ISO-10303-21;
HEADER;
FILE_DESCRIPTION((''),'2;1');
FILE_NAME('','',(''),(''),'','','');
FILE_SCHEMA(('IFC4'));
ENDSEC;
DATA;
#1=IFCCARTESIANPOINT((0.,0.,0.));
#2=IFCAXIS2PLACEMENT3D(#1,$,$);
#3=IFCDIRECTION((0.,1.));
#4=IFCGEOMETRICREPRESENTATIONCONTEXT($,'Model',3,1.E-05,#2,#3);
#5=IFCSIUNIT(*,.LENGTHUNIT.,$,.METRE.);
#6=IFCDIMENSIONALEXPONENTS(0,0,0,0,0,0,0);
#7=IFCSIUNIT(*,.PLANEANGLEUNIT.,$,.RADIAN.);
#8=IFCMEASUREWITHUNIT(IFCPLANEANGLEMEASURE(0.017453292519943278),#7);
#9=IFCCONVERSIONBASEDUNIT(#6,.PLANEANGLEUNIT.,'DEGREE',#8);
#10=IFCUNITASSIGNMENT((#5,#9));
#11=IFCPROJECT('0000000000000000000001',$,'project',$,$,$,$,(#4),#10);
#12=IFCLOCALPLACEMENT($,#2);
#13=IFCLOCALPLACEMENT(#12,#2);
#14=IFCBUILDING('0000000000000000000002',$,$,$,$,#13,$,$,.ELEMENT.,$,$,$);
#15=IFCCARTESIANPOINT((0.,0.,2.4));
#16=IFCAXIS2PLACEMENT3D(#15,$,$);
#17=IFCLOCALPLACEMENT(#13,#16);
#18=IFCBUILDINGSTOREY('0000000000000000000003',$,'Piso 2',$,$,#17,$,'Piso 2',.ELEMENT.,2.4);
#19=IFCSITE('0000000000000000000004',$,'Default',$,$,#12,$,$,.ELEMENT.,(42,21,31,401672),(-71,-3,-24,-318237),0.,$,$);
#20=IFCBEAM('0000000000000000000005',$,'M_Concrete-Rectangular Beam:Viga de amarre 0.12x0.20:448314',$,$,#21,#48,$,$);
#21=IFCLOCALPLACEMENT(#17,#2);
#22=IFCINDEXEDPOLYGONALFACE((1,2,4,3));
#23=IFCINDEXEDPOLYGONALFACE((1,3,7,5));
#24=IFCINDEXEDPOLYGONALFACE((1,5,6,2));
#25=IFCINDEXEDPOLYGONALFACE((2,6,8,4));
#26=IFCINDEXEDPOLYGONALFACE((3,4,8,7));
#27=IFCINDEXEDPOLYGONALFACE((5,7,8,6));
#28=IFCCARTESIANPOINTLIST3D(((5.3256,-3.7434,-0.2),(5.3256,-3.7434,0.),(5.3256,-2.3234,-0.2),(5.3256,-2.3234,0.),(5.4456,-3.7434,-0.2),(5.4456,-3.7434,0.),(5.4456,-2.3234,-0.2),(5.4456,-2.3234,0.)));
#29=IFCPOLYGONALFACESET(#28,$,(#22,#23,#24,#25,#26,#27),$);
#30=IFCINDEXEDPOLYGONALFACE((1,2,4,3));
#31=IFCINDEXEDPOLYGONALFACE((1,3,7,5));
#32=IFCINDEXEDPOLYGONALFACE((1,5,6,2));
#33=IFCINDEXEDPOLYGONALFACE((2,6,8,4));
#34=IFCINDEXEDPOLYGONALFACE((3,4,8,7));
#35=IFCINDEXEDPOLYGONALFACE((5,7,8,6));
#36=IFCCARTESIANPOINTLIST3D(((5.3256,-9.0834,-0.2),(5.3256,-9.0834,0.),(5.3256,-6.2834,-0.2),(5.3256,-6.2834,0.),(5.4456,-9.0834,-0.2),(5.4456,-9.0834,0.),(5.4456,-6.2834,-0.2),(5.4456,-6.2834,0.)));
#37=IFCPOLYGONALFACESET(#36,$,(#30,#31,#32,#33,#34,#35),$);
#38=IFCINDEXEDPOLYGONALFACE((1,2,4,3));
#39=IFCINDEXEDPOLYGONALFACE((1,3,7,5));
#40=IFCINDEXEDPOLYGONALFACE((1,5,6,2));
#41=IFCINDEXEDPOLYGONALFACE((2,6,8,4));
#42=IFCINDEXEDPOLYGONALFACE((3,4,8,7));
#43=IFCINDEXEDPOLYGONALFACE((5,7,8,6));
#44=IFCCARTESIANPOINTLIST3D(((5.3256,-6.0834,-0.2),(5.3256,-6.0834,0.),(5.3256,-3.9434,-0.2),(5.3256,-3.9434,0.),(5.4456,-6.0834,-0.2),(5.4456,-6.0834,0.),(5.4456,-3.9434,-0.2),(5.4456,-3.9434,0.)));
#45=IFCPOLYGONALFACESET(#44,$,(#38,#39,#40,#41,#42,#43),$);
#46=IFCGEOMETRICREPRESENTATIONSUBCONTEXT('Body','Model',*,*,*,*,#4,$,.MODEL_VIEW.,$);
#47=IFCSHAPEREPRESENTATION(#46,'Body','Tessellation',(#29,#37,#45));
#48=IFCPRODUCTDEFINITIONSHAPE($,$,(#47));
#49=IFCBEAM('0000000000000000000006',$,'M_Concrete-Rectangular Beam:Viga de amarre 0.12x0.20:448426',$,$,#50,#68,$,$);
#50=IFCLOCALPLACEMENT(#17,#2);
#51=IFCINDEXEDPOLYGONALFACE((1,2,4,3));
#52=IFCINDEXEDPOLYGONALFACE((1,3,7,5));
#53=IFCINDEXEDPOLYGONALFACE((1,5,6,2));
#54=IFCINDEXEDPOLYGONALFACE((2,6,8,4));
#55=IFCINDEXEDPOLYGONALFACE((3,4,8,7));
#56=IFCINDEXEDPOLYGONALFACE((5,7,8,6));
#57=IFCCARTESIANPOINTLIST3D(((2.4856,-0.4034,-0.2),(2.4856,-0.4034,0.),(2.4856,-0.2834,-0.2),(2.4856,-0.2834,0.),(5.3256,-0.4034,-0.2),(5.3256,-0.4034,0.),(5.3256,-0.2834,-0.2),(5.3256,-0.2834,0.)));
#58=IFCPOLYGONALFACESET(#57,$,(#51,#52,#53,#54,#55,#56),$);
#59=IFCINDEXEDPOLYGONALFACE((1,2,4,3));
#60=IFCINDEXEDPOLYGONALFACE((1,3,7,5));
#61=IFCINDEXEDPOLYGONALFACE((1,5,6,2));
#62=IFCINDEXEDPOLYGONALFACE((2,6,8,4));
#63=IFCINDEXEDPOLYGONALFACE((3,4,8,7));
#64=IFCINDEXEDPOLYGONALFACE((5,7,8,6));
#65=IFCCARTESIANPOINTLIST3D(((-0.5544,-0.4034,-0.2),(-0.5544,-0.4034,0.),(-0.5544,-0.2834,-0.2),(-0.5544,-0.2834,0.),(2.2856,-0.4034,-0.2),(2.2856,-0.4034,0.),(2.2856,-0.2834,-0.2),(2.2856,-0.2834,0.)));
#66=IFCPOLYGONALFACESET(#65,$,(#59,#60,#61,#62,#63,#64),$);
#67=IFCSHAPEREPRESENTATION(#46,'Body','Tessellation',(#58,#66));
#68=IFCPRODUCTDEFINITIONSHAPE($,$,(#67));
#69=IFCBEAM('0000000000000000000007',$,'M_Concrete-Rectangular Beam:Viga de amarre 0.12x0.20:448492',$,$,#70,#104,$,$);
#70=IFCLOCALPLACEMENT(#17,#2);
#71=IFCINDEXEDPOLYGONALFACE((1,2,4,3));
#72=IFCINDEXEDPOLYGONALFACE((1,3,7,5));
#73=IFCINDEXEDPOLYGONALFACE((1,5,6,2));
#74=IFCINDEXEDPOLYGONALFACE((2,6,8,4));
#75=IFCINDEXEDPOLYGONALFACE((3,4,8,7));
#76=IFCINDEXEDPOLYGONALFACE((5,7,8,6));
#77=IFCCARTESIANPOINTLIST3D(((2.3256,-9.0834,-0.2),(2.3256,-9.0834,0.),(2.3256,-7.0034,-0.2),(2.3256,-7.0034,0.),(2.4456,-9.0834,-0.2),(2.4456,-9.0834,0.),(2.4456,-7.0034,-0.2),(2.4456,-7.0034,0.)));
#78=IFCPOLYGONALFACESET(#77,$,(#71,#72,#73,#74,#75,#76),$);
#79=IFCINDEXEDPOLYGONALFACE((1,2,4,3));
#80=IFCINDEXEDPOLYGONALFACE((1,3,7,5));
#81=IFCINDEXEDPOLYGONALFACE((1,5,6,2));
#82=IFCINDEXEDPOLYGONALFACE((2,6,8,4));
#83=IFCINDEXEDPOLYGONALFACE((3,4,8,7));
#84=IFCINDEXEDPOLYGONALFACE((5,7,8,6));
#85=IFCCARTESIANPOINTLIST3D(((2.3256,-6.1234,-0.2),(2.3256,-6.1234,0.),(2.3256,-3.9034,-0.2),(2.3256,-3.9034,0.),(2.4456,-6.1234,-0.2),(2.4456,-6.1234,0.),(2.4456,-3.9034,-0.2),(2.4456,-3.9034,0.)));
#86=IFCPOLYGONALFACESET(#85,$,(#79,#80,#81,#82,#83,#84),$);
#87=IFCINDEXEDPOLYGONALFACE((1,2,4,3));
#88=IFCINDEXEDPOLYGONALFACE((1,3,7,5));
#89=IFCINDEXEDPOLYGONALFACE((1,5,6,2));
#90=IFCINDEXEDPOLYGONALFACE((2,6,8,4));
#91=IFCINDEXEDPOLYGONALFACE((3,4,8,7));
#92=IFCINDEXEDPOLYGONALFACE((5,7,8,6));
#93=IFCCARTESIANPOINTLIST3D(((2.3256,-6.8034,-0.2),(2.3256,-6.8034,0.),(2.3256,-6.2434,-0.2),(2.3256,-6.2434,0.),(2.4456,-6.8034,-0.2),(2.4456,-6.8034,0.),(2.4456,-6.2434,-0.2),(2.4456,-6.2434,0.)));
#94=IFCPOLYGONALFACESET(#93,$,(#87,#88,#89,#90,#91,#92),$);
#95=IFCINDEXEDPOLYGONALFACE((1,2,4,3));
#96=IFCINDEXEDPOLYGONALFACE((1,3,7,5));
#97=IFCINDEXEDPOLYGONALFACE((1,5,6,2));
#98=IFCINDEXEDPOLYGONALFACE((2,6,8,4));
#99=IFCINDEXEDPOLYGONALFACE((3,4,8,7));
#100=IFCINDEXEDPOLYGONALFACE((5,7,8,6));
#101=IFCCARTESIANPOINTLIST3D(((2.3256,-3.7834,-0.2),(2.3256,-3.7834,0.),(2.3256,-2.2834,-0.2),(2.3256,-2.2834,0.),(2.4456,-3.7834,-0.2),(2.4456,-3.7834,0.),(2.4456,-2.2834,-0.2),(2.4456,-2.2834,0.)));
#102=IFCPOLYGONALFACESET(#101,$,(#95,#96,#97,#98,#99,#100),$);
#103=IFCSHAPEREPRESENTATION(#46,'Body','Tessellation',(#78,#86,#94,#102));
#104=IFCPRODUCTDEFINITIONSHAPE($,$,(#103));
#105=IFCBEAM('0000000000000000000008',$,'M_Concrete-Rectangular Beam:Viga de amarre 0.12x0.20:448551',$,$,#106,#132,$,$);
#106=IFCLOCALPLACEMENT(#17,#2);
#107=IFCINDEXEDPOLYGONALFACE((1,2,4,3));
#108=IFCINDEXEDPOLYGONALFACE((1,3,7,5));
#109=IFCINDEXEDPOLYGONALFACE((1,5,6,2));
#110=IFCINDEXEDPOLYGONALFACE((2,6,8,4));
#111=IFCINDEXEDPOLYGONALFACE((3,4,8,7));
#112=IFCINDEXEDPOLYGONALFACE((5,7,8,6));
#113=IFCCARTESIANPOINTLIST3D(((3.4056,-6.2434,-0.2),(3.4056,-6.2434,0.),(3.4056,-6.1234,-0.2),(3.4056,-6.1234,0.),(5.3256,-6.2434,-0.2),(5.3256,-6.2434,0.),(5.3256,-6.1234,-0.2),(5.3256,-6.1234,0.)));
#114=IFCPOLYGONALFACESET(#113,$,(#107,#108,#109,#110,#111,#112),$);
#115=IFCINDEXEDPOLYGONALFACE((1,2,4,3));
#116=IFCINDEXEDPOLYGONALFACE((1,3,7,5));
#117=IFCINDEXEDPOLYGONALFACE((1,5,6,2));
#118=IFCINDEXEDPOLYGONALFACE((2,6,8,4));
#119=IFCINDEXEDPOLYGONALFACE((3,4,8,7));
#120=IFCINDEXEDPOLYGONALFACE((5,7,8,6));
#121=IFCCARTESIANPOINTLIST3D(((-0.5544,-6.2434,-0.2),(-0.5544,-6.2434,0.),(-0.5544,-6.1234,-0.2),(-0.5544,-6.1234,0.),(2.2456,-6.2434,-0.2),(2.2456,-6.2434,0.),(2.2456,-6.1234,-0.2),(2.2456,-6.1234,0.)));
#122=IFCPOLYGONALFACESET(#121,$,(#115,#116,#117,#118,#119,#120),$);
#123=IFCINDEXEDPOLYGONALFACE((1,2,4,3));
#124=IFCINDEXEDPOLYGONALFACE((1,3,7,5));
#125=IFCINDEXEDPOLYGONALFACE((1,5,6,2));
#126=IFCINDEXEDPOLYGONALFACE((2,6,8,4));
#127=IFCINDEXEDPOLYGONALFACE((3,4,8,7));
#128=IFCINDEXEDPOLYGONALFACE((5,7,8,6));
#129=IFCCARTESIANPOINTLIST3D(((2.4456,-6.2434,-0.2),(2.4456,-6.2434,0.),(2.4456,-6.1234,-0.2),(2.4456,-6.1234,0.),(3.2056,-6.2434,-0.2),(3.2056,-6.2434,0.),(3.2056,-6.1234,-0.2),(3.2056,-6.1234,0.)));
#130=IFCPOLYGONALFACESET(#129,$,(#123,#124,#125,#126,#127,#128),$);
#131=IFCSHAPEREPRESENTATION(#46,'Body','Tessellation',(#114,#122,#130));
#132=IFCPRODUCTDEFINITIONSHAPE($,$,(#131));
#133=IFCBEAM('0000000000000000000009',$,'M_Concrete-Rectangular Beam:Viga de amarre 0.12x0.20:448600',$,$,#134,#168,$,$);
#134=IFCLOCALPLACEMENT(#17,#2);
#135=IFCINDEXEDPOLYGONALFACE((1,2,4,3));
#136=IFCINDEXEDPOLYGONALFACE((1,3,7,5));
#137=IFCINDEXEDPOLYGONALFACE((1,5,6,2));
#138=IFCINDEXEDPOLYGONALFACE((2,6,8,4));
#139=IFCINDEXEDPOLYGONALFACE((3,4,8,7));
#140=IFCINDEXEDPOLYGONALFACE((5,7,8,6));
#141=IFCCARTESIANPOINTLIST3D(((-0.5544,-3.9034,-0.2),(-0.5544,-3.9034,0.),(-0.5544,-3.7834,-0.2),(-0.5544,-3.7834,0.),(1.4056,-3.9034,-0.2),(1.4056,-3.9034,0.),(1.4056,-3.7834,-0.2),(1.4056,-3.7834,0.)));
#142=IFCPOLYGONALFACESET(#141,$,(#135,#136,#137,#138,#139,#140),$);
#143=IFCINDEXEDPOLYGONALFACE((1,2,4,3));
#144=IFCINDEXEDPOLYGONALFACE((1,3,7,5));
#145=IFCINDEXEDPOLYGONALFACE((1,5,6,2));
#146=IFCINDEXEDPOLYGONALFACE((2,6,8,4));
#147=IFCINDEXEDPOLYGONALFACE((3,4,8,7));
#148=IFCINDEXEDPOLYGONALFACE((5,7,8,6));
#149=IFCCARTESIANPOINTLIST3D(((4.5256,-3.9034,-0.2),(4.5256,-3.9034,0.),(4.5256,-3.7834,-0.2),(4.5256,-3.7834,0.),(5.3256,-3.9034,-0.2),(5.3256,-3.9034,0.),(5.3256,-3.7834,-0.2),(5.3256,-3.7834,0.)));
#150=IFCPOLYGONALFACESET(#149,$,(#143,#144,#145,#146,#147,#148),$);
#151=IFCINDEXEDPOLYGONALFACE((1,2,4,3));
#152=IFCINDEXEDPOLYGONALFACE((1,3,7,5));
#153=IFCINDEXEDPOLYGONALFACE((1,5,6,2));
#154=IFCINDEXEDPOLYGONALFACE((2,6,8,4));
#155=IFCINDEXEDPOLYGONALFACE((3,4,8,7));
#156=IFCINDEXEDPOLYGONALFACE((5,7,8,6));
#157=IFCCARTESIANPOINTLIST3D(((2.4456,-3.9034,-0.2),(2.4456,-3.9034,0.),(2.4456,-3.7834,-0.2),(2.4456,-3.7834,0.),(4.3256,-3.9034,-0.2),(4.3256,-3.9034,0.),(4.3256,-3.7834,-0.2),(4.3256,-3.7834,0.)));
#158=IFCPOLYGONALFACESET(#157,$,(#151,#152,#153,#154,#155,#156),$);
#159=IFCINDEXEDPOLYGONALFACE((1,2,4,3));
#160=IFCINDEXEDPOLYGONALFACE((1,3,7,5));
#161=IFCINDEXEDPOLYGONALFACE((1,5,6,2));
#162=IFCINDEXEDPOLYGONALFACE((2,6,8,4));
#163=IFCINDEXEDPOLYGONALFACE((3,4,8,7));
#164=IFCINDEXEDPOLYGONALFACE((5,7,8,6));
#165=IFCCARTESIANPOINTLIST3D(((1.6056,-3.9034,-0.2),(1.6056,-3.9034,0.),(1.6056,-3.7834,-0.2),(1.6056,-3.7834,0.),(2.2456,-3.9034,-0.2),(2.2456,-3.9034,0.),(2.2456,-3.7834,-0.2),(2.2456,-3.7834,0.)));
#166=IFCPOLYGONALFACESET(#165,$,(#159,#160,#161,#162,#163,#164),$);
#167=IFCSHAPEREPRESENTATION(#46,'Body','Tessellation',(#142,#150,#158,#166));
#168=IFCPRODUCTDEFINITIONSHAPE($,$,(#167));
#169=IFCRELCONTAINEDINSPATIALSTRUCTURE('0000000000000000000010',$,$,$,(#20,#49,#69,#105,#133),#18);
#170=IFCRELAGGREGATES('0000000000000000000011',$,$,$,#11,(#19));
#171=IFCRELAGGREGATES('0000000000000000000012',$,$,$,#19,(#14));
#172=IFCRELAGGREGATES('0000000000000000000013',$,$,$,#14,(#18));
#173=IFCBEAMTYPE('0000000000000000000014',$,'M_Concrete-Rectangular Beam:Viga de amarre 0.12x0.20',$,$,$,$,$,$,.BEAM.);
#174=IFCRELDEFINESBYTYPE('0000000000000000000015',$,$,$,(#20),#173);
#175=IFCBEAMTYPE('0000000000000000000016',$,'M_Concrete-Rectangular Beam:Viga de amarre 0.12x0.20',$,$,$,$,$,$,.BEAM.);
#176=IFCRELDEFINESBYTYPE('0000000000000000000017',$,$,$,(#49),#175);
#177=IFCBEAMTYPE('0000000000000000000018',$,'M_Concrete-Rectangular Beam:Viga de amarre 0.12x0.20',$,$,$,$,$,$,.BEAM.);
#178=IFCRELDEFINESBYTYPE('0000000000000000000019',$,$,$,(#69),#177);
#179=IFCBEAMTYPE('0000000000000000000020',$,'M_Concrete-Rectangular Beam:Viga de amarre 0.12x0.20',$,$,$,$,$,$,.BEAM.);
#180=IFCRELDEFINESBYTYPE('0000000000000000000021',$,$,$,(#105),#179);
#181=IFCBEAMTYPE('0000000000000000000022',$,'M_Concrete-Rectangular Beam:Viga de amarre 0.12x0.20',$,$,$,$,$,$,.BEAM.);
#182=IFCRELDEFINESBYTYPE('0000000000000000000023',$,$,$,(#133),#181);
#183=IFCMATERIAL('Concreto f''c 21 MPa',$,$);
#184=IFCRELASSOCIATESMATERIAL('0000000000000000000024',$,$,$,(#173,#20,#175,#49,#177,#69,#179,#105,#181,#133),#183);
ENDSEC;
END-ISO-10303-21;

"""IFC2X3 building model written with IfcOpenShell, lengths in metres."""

from ifc_helpers import new_model, entity, si_unit, converted_unit, direction, frame, frame_2d, origin, origin_2d_with_axis, place, context, subcontext, project, spatial, rectangle, extrude, source, transform, mapped, material, type_object, type_shapes, element, save


model = new_model("IFC2X3")

# Units and contexts
model_context = context("Model", 3, precision=1e-05, world=origin(), true_north=direction((0.0, 1.0)))
body_context = subcontext(model_context, "Body", "Model", "MODEL_VIEW")
ifc_project = project(units=[si_unit("LENGTHUNIT", "METRE"), converted_unit("PLANEANGLEUNIT", "DEGREE", entity("IfcPlaneAngleMeasure", 0.017453292519943278), si_unit("PLANEANGLEUNIT", "RADIAN"), dimensions=[0, 0, 0, 0, 0, 0, 0])], contexts=[model_context])

# Site, building, storey
site_placement = place(None, origin())
site = spatial("IfcSite", under=ifc_project, at=site_placement, Name="Default", CompositionType="ELEMENT", RefLatitude=(42, 21, 31, 401672), RefLongitude=(-71, -3, -24, -318237), RefElevation=0.0)
building_placement = place(site_placement, origin())
building = spatial("IfcBuilding", under=site, at=building_placement, CompositionType="ELEMENT")
storey_placement = place(building_placement, frame((0.0, 0.0, 2.4)))
storey = spatial("IfcBuildingStorey", under=building, at=storey_placement, Name="Piso 2", LongName="Piso 2", CompositionType="ELEMENT", Elevation=2.4)

# Shared definitions
ifc_material_1 = material(Name="Concreto f'c 21 MPa")

# Beams
beam_type_1 = type_object("IfcBeamType", Name="M_Concrete-Rectangular Beam:Viga de amarre 0.12x0.20", PredefinedType="BEAM", material=ifc_material_1)
shared_shape_1 = source(origin(), body_context, "Body", "SweptSolid", [
    extrude(rectangle(XDim=0.2, YDim=0.12, at=frame_2d((0.0, 0.0), x_axis=(0.0, 1.0))), frame((5.3856, -3.7434, 2.3), z_axis=(0.0, 1.0, 0.0), x_axis=(-1.0, 0.0, 0.0)), (0.0, 0.0, 1.0), 1.42),
    extrude(rectangle(XDim=0.2, YDim=0.12, at=frame_2d((0.0, 0.0), x_axis=(0.0, 1.0))), frame((5.3856, -9.0834, 2.3), z_axis=(0.0, 1.0, 0.0), x_axis=(-1.0, 0.0, 0.0)), (0.0, 0.0, 1.0), 2.8),
    extrude(rectangle(XDim=0.2, YDim=0.12, at=frame_2d((0.0, 0.0), x_axis=(0.0, 1.0))), frame((5.3856, -6.0834, 2.3), z_axis=(0.0, 1.0, 0.0), x_axis=(-1.0, 0.0, 0.0)), (0.0, 0.0, 1.0), 2.14),
])
type_shapes(beam_type_1, [shared_shape_1])
beam_1_placement = place(storey_placement, frame((0.0, 0.0, -2.4)))
element("IfcBeam", 1, at=beam_1_placement, inside=storey, type_object=beam_type_1, material=ifc_material_1, Name="M_Concrete-Rectangular Beam:Viga de amarre 0.12x0.20:448314", context=body_context, shape_type="MappedRepresentation", body=[
    mapped(shared_shape_1, transform((0.0, 0.0, 0.0), scale=1.0)),
])
beam_type_2 = type_object("IfcBeamType", Name="M_Concrete-Rectangular Beam:Viga de amarre 0.12x0.20", PredefinedType="BEAM", material=ifc_material_1)
shared_shape_2 = source(origin(), body_context, "Body", "SweptSolid", [
    extrude(rectangle(XDim=0.2, YDim=0.12, at=origin_2d_with_axis()), frame((2.4856, -0.3434, 2.3), z_axis=(1.0, 0.0, 0.0), x_axis=(0.0, 0.0, -1.0)), (0.0, 0.0, 1.0), 2.84),
    extrude(rectangle(XDim=0.2, YDim=0.12, at=origin_2d_with_axis()), frame((-0.5544, -0.3434, 2.3), z_axis=(1.0, 0.0, 0.0), x_axis=(0.0, 0.0, -1.0)), (0.0, 0.0, 1.0), 2.84),
])
type_shapes(beam_type_2, [shared_shape_2])
beam_2_placement = place(storey_placement, frame((0.0, 0.0, -2.4)))
element("IfcBeam", 2, at=beam_2_placement, inside=storey, type_object=beam_type_2, material=ifc_material_1, Name="M_Concrete-Rectangular Beam:Viga de amarre 0.12x0.20:448426", context=body_context, shape_type="MappedRepresentation", body=[
    mapped(shared_shape_2, transform((0.0, 0.0, 0.0), scale=1.0)),
])
beam_type_3 = type_object("IfcBeamType", Name="M_Concrete-Rectangular Beam:Viga de amarre 0.12x0.20", PredefinedType="BEAM", material=ifc_material_1)
shared_shape_3 = source(origin(), body_context, "Body", "SweptSolid", [
    extrude(rectangle(XDim=0.2, YDim=0.12, at=frame_2d((0.0, 0.0), x_axis=(0.0, 1.0))), frame((2.3856, -7.0034, 2.3), z_axis=(0.0, -1.0, 0.0), x_axis=(-1.0, 0.0, 0.0)), (0.0, 0.0, 1.0), 2.08),
    extrude(rectangle(XDim=0.2, YDim=0.12, at=frame_2d((0.0, 0.0), x_axis=(0.0, 1.0))), frame((2.3856, -3.9034, 2.3), z_axis=(0.0, -1.0, 0.0), x_axis=(-1.0, 0.0, 0.0)), (0.0, 0.0, 1.0), 2.22),
    extrude(rectangle(XDim=0.2, YDim=0.12, at=frame_2d((0.0, 0.0), x_axis=(0.0, 1.0))), frame((2.3856, -6.2434, 2.3), z_axis=(0.0, -1.0, 0.0), x_axis=(-1.0, 0.0, 0.0)), (0.0, 0.0, 1.0), 0.56),
    extrude(rectangle(XDim=0.2, YDim=0.12, at=frame_2d((0.0, 0.0), x_axis=(0.0, 1.0))), frame((2.3856, -2.2834, 2.3), z_axis=(0.0, -1.0, 0.0), x_axis=(-1.0, 0.0, 0.0)), (0.0, 0.0, 1.0), 1.5),
])
type_shapes(beam_type_3, [shared_shape_3])
beam_3_placement = place(storey_placement, frame((0.0, 0.0, -2.4)))
element("IfcBeam", 3, at=beam_3_placement, inside=storey, type_object=beam_type_3, material=ifc_material_1, Name="M_Concrete-Rectangular Beam:Viga de amarre 0.12x0.20:448492", context=body_context, shape_type="MappedRepresentation", body=[
    mapped(shared_shape_3, transform((0.0, 0.0, 0.0), scale=1.0)),
])
beam_type_4 = type_object("IfcBeamType", Name="M_Concrete-Rectangular Beam:Viga de amarre 0.12x0.20", PredefinedType="BEAM", material=ifc_material_1)
shared_shape_4 = source(origin(), body_context, "Body", "SweptSolid", [
    extrude(rectangle(XDim=0.2, YDim=0.12, at=frame_2d((0.0, 0.0), x_axis=(1.0, 0.0))), frame((3.4056, -6.1834, 2.3), z_axis=(1.0, 0.0, 0.0), x_axis=(0.0, 0.0, -1.0)), (0.0, 0.0, 1.0), 1.92),
    extrude(rectangle(XDim=0.2, YDim=0.12, at=frame_2d((0.0, 0.0), x_axis=(1.0, 0.0))), frame((-0.5544, -6.1834, 2.3), z_axis=(1.0, 0.0, 0.0), x_axis=(0.0, 0.0, -1.0)), (0.0, 0.0, 1.0), 2.8),
    extrude(rectangle(XDim=0.2, YDim=0.12, at=frame_2d((0.0, 0.0), x_axis=(1.0, 0.0))), frame((2.4456, -6.1834, 2.3), z_axis=(1.0, 0.0, 0.0), x_axis=(0.0, 0.0, -1.0)), (0.0, 0.0, 1.0), 0.76),
])
type_shapes(beam_type_4, [shared_shape_4])
beam_4_placement = place(storey_placement, frame((0.0, 0.0, -2.4)))
element("IfcBeam", 4, at=beam_4_placement, inside=storey, type_object=beam_type_4, material=ifc_material_1, Name="M_Concrete-Rectangular Beam:Viga de amarre 0.12x0.20:448551", context=body_context, shape_type="MappedRepresentation", body=[
    mapped(shared_shape_4, transform((0.0, 0.0, 0.0), scale=1.0)),
])
beam_type_5 = type_object("IfcBeamType", Name="M_Concrete-Rectangular Beam:Viga de amarre 0.12x0.20", PredefinedType="BEAM", material=ifc_material_1)
shared_shape_5 = source(origin(), body_context, "Body", "SweptSolid", [
    extrude(rectangle(XDim=0.2, YDim=0.12, at=origin_2d_with_axis()), frame((1.4056, -3.8434, 2.3), z_axis=(-1.0, 0.0, 0.0), x_axis=(0.0, 0.0, -1.0)), (0.0, 0.0, 1.0), 1.96),
    extrude(rectangle(XDim=0.2, YDim=0.12, at=origin_2d_with_axis()), frame((5.3256, -3.8434, 2.3), z_axis=(-1.0, 0.0, 0.0), x_axis=(0.0, 0.0, -1.0)), (0.0, 0.0, 1.0), 0.8),
    extrude(rectangle(XDim=0.2, YDim=0.12, at=frame_2d((0.0, 0.0), x_axis=(1.0, 0.0))), frame((4.3256, -3.8434, 2.3), z_axis=(-1.0, 0.0, 0.0), x_axis=(0.0, 0.0, -1.0)), (0.0, 0.0, 1.0), 1.88),
    extrude(rectangle(XDim=0.2, YDim=0.12, at=origin_2d_with_axis()), frame((2.2456, -3.8434, 2.3), z_axis=(-1.0, 0.0, 0.0), x_axis=(0.0, 0.0, -1.0)), (0.0, 0.0, 1.0), 0.64),
])
type_shapes(beam_type_5, [shared_shape_5])
beam_5_placement = place(storey_placement, frame((0.0, 0.0, -2.4)))
element("IfcBeam", 5, at=beam_5_placement, inside=storey, type_object=beam_type_5, material=ifc_material_1, Name="M_Concrete-Rectangular Beam:Viga de amarre 0.12x0.20:448600", context=body_context, shape_type="MappedRepresentation", body=[
    mapped(shared_shape_5, transform((0.0, 0.0, 0.0), scale=1.0)),
])

save(model, "model.ifc")
